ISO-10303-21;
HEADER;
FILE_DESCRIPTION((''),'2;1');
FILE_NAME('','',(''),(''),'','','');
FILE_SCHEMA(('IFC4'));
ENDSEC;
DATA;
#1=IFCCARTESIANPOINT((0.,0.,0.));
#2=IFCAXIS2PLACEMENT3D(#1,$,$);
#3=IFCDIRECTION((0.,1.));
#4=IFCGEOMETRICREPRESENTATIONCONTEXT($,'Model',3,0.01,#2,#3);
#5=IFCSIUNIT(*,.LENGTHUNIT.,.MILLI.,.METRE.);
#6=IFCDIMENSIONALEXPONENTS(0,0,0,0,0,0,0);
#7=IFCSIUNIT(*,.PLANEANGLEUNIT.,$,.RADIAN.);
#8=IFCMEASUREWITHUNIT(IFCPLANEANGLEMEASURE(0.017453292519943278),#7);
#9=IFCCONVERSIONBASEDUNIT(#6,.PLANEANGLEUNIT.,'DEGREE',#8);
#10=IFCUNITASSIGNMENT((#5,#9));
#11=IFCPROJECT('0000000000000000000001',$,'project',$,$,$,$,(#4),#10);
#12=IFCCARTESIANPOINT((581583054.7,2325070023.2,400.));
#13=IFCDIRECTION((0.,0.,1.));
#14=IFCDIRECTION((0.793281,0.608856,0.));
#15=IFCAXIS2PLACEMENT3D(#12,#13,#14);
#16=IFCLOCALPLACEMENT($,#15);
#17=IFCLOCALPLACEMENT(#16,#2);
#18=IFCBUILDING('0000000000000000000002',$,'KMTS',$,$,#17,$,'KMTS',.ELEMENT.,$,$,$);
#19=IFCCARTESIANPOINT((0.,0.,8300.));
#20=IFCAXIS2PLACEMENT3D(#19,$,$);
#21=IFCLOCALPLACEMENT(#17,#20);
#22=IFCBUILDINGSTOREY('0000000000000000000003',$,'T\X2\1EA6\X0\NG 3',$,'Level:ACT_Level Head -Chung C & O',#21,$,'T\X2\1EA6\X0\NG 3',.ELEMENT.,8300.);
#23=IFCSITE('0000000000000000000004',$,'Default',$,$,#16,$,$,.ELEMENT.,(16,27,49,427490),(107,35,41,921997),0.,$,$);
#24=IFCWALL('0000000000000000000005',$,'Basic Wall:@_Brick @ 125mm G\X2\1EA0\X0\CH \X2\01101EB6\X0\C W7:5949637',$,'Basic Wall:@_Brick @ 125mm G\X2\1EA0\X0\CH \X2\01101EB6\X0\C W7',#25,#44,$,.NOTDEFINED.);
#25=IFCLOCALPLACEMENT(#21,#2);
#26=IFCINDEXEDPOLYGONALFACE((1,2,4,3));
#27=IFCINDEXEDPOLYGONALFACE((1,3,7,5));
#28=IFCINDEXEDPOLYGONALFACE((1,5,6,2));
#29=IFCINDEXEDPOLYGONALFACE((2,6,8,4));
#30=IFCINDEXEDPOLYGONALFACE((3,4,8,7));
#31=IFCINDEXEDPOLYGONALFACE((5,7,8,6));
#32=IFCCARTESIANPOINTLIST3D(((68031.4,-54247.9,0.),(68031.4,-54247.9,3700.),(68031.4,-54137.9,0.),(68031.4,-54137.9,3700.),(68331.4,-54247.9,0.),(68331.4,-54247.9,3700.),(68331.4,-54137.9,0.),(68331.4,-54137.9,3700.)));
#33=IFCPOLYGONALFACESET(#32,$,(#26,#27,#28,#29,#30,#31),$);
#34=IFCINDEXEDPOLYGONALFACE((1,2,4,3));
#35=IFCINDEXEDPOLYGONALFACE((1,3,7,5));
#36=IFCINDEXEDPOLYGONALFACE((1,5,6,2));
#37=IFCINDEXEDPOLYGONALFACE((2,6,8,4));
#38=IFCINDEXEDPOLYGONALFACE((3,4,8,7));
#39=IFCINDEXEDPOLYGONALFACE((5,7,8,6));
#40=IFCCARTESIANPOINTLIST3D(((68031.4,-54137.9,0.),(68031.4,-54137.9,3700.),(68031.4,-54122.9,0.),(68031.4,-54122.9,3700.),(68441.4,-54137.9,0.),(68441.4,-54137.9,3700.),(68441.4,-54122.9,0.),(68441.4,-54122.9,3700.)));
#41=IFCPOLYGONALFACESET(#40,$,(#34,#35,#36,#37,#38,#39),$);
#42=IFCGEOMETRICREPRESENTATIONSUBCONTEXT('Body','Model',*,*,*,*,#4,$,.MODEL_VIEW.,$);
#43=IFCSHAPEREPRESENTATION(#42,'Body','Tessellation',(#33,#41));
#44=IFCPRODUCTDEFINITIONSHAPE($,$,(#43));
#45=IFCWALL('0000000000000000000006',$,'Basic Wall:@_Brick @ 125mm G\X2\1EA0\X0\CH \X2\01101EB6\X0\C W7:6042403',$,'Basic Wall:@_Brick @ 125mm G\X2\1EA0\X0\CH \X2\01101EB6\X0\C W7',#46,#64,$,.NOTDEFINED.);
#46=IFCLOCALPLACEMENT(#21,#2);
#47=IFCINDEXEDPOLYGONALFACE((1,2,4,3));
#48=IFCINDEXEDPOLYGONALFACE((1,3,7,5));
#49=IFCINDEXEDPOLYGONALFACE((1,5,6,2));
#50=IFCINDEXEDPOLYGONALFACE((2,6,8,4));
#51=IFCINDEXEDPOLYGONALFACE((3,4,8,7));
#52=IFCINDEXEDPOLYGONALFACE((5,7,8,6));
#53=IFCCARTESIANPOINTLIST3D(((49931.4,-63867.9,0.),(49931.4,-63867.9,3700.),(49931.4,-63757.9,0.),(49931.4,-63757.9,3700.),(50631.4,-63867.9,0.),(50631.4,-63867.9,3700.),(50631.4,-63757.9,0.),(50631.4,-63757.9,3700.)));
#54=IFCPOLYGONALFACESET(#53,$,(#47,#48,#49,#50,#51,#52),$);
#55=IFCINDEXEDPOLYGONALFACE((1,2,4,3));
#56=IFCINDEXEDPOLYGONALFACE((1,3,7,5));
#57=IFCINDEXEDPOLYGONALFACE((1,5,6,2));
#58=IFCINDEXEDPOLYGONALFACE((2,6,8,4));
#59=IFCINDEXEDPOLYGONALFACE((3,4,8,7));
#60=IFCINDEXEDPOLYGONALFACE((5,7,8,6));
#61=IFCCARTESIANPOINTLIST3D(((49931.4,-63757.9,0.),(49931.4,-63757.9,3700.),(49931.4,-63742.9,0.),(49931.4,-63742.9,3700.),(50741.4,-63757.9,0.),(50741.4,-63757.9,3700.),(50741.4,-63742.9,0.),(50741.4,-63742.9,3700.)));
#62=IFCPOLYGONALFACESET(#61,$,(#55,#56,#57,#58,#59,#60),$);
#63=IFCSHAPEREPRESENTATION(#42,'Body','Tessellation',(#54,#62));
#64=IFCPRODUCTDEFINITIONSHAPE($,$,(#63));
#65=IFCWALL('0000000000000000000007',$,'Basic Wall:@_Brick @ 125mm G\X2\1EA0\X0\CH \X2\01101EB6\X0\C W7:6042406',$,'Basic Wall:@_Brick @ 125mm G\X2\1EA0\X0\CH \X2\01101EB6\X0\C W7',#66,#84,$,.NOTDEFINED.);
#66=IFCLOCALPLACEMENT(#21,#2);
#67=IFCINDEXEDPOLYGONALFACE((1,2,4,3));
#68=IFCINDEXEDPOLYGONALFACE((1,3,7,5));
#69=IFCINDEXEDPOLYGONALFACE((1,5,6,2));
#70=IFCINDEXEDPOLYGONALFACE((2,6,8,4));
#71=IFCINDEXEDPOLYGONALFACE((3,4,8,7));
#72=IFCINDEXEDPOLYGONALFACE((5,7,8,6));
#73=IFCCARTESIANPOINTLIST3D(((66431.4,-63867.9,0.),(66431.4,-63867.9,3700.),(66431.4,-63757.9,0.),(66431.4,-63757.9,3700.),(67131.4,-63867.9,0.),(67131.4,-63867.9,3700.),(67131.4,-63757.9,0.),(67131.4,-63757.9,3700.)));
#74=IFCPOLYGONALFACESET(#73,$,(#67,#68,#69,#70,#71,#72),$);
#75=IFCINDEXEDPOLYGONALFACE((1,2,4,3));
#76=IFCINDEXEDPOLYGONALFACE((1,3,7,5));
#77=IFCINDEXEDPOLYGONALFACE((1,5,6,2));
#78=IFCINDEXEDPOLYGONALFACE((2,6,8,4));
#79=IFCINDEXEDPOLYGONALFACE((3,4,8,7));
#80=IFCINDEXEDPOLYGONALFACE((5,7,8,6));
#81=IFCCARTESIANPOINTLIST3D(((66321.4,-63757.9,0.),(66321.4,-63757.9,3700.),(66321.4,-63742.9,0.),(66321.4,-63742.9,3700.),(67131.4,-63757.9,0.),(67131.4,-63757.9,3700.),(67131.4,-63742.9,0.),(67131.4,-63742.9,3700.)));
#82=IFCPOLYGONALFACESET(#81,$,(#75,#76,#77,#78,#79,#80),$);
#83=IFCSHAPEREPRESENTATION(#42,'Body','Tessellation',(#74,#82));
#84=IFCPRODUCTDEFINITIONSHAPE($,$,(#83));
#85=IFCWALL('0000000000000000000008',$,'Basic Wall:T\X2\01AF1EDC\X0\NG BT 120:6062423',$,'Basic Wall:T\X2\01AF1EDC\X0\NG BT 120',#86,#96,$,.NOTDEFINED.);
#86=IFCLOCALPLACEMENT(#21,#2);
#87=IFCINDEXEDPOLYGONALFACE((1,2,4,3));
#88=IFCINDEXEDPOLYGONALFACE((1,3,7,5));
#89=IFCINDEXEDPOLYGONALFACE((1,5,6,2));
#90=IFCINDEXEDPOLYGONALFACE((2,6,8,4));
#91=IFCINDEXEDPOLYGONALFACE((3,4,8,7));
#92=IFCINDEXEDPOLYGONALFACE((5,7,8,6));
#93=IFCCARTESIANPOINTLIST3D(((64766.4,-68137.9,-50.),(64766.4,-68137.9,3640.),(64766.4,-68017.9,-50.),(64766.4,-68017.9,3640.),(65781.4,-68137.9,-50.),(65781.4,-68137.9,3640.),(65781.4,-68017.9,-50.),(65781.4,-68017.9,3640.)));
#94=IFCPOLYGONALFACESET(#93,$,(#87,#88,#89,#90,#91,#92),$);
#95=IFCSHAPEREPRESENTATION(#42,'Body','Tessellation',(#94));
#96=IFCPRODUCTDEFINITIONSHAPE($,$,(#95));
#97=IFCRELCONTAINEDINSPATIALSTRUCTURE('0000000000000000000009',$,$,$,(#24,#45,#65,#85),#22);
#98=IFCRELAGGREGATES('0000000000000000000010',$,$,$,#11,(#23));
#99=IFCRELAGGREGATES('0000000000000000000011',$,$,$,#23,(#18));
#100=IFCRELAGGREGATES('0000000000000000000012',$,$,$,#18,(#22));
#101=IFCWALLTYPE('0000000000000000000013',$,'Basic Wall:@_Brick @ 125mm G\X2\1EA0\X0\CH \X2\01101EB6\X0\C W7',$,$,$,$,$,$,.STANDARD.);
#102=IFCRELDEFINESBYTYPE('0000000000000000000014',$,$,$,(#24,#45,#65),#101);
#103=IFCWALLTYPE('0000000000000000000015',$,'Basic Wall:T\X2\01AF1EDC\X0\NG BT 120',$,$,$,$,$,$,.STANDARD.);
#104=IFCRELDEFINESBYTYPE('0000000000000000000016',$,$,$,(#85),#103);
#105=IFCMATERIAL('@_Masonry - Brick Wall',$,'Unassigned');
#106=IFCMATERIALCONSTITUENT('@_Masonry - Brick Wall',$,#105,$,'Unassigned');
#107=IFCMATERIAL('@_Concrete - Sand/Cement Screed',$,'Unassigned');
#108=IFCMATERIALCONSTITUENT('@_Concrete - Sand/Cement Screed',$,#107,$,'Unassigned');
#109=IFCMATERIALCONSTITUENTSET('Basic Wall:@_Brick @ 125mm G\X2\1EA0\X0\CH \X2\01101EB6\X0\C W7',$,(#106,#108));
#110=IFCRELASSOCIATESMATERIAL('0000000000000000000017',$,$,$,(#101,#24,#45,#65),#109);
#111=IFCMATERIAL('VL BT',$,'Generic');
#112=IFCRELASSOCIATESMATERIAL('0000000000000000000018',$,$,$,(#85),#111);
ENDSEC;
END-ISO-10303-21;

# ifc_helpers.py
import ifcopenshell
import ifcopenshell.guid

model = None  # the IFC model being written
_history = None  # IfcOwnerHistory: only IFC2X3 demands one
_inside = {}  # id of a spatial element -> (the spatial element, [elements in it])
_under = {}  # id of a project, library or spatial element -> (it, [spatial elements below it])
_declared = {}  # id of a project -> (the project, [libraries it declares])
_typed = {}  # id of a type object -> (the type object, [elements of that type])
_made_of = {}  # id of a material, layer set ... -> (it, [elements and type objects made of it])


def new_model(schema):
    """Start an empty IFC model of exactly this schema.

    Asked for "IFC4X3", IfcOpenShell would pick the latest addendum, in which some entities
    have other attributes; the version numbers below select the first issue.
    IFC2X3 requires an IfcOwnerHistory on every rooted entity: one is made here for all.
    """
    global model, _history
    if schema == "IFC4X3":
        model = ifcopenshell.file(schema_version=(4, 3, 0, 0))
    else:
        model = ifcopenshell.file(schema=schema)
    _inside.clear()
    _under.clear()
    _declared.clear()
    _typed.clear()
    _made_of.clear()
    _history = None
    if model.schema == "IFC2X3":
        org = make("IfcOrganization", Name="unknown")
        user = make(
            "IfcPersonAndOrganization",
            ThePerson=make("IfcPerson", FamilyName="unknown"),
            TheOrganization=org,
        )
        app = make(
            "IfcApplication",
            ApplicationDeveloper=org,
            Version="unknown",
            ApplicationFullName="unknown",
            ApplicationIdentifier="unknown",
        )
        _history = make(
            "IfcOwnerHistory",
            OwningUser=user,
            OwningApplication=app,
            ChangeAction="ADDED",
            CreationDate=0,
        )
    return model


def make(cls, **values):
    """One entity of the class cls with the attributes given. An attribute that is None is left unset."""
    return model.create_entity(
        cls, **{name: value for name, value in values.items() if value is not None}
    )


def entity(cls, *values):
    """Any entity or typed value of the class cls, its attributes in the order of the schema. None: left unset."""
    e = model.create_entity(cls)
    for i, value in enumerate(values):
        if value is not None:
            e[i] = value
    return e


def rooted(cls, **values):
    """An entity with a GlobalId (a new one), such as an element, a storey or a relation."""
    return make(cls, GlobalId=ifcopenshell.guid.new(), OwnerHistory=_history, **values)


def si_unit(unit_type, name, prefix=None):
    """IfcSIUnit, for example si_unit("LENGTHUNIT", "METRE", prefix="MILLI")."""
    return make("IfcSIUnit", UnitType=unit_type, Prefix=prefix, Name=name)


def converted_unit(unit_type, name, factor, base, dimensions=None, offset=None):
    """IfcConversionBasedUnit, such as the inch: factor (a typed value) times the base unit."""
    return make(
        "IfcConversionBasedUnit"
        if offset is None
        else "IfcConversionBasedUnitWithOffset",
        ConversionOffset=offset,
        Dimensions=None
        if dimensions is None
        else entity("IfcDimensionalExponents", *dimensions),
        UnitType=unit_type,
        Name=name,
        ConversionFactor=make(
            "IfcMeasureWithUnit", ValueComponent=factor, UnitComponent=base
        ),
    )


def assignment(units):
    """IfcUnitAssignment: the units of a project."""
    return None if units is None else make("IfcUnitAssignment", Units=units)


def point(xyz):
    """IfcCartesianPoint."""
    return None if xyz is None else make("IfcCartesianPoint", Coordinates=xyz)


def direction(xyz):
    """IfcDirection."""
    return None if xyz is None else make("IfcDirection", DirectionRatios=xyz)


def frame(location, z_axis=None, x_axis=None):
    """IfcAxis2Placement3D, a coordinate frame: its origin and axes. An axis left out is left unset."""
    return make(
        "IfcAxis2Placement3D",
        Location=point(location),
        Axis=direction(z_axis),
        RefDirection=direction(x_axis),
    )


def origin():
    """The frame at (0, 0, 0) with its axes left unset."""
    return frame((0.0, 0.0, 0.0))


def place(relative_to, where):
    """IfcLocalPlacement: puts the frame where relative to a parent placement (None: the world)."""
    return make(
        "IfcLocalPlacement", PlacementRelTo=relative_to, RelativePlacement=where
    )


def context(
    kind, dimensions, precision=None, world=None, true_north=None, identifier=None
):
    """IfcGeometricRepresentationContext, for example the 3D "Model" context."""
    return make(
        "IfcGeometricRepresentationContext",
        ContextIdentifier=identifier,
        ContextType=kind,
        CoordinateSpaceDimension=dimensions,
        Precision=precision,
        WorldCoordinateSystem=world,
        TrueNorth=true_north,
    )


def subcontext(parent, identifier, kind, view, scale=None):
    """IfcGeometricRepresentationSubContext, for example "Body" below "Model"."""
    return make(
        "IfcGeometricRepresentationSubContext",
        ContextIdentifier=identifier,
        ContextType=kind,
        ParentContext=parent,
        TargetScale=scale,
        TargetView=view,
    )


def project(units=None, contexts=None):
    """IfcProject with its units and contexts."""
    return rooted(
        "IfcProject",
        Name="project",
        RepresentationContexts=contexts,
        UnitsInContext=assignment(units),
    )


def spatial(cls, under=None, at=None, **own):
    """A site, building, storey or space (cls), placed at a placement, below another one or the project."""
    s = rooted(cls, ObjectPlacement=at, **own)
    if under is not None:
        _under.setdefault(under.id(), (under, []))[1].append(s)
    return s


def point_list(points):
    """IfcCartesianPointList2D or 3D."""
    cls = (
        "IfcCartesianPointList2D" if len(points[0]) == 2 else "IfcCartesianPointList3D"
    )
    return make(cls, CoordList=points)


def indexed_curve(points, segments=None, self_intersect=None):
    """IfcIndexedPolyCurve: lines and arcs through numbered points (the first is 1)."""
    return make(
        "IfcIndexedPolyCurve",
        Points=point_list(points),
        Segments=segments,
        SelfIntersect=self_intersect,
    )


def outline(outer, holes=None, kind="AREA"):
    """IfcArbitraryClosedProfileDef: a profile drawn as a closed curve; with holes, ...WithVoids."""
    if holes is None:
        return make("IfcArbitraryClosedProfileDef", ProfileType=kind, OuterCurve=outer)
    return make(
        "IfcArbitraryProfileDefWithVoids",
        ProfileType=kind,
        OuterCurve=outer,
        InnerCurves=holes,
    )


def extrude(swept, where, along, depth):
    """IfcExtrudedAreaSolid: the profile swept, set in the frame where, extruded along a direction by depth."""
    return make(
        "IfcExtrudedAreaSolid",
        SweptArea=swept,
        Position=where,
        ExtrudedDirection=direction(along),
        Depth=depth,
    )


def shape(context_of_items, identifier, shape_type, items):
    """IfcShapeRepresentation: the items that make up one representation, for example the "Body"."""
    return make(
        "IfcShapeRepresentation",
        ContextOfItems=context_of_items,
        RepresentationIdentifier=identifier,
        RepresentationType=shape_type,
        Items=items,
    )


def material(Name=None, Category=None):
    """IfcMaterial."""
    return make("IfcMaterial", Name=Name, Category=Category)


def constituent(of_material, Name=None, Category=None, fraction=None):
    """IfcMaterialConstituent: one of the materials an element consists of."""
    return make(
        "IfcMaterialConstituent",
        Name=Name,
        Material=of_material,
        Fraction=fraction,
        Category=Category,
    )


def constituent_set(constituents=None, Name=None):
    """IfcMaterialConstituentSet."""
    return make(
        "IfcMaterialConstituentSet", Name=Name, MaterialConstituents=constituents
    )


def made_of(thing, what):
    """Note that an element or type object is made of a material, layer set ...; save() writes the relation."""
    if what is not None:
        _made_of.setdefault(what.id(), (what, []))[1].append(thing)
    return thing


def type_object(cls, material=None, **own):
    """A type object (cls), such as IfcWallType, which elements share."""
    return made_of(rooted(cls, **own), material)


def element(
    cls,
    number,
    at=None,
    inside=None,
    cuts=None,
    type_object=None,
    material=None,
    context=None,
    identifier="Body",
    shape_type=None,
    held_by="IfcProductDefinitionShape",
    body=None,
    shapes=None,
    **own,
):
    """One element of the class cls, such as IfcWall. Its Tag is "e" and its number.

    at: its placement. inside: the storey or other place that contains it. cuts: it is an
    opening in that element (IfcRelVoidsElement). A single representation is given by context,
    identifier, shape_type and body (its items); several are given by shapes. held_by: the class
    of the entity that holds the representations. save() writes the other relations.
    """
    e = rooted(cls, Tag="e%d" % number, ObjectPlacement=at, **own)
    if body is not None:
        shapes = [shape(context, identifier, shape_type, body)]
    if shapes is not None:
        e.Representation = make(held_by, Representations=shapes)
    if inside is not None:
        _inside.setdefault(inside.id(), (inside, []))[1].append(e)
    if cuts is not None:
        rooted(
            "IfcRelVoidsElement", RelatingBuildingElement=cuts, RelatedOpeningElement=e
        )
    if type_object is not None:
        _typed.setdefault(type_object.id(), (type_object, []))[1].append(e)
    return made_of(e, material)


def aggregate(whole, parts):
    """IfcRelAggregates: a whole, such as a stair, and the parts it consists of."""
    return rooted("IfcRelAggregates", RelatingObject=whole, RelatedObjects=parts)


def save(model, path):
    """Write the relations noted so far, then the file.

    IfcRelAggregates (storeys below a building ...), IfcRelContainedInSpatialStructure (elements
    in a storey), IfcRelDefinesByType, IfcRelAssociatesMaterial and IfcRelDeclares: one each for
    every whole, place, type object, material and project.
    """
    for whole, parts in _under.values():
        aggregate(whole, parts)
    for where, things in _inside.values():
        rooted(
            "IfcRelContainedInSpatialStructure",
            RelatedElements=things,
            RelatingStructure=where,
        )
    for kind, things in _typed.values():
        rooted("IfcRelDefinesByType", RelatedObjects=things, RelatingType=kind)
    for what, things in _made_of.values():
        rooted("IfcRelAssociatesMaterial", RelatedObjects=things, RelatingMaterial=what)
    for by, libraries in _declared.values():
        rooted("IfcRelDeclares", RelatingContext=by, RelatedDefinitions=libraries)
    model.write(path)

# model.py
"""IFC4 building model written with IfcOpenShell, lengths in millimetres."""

from ifc_helpers import new_model, entity, si_unit, converted_unit, direction, frame, origin, place, context, subcontext, project, spatial, indexed_curve, outline, extrude, material, constituent, constituent_set, type_object, element, save


model = new_model("IFC4")

# Units and contexts
model_context = context("Model", 3, precision=0.01, world=origin(), true_north=direction((0.0, 1.0)))
body_context = subcontext(model_context, "Body", "Model", "MODEL_VIEW")
ifc_project = project(units=[si_unit("LENGTHUNIT", "METRE", prefix="MILLI"), converted_unit("PLANEANGLEUNIT", "DEGREE", entity("IfcPlaneAngleMeasure", 0.017453292519943278), si_unit("PLANEANGLEUNIT", "RADIAN"), dimensions=[0, 0, 0, 0, 0, 0, 0])], contexts=[model_context])

# Site, building, storey
site_placement = place(None, frame((581583054.7, 2325070023.2, 400.0), z_axis=(0.0, 0.0, 1.0), x_axis=(0.793281, 0.608856, 0.0)))
site = spatial("IfcSite", under=ifc_project, at=site_placement, Name="Default", CompositionType="ELEMENT", RefLatitude=(16, 27, 49, 427490), RefLongitude=(107, 35, 41, 921997), RefElevation=0.0)
building_placement = place(site_placement, origin())
building = spatial("IfcBuilding", under=site, at=building_placement, Name="KMTS", LongName="KMTS", CompositionType="ELEMENT")
storey_placement = place(building_placement, frame((0.0, 0.0, 8300.0)))
storey = spatial("IfcBuildingStorey", under=building, at=storey_placement, Name="TẦNG 3", ObjectType="Level:ACT_Level Head -Chung C & O", LongName="TẦNG 3", CompositionType="ELEMENT", Elevation=8300.0)

# Shared definitions
ifc_material_1 = material(Name="VL BT", Category="Generic")

# Walls
ifc_material_2 = material(Name="@_Masonry - Brick Wall", Category="Unassigned")
ifc_constituent_1 = constituent(ifc_material_2, Name="@_Masonry - Brick Wall", Category="Unassigned")
ifc_material_3 = material(Name="@_Concrete - Sand/Cement Screed", Category="Unassigned")
ifc_constituent_2 = constituent(ifc_material_3, Name="@_Concrete - Sand/Cement Screed", Category="Unassigned")
ifc_constituent_set_1 = constituent_set(constituents=[ifc_constituent_1, ifc_constituent_2], Name="Basic Wall:@_Brick @ 125mm GẠCH ĐẶC W7")
wall_type_1 = type_object("IfcWallType", Name="Basic Wall:@_Brick @ 125mm GẠCH ĐẶC W7", PredefinedType="STANDARD", material=ifc_constituent_set_1)
wall_1_placement = place(storey_placement, frame((68331.4, -54185.4, 0.0), z_axis=(0.0, 0.0, 1.0), x_axis=(-1.0, 0.0, 0.0)))
element("IfcWall", 1, at=wall_1_placement, inside=storey, type_object=wall_type_1, material=ifc_constituent_set_1, Name="Basic Wall:@_Brick @ 125mm GẠCH ĐẶC W7:5949637", ObjectType="Basic Wall:@_Brick @ 125mm GẠCH ĐẶC W7", PredefinedType="NOTDEFINED", context=body_context, shape_type="SweptSolid", body=[
    extrude(outline(indexed_curve([(-55.0, -150.0), (55.0, -150.0), (55.0, 150.0), (-55.0, 150.0), (-55.0, -150.0)], self_intersect=False)), frame((150.0, 7.5, 0.0), z_axis=(0.0, 0.0, 1.0), x_axis=(0.0, -1.0, 0.0)), (0.0, 0.0, 1.0), 3700.0),
    extrude(outline(indexed_curve([(-7.5, -205.0), (7.5, -205.0), (7.5, 205.0), (-7.5, 205.0), (-7.5, -205.0)], self_intersect=False)), frame((95.0, -55.0, 0.0), z_axis=(0.0, 0.0, 1.0), x_axis=(0.0, 1.0, 0.0)), (0.0, 0.0, 1.0), 3700.0),
])
wall_2_placement = place(storey_placement, frame((50631.4, -63805.4, 0.0), z_axis=(0.0, 0.0, 1.0), x_axis=(-1.0, 0.0, 0.0)))
element("IfcWall", 2, at=wall_2_placement, inside=storey, type_object=wall_type_1, material=ifc_constituent_set_1, Name="Basic Wall:@_Brick @ 125mm GẠCH ĐẶC W7:6042403", ObjectType="Basic Wall:@_Brick @ 125mm GẠCH ĐẶC W7", PredefinedType="NOTDEFINED", context=body_context, shape_type="SweptSolid", body=[
    extrude(outline(indexed_curve([(-55.0, -350.0), (55.0, -350.0), (55.0, 350.0), (-55.0, 350.0), (-55.0, -350.0)], self_intersect=False)), frame((350.0, 7.5, 0.0), z_axis=(0.0, 0.0, 1.0), x_axis=(0.0, -1.0, 0.0)), (0.0, 0.0, 1.0), 3700.0),
    extrude(outline(indexed_curve([(-7.5, -405.0), (7.5, -405.0), (7.5, 405.0), (-7.5, 405.0), (-7.5, -405.0)], self_intersect=False)), frame((295.0, -55.0, 0.0), z_axis=(0.0, 0.0, 1.0), x_axis=(0.0, 1.0, 0.0)), (0.0, 0.0, 1.0), 3700.0),
])
wall_3_placement = place(storey_placement, frame((66431.4, -63805.4, 0.0)))
element("IfcWall", 3, at=wall_3_placement, inside=storey, type_object=wall_type_1, material=ifc_constituent_set_1, Name="Basic Wall:@_Brick @ 125mm GẠCH ĐẶC W7:6042406", ObjectType="Basic Wall:@_Brick @ 125mm GẠCH ĐẶC W7", PredefinedType="NOTDEFINED", context=body_context, shape_type="SweptSolid", body=[
    extrude(outline(indexed_curve([(-55.0, -350.0), (55.0, -350.0), (55.0, 350.0), (-55.0, 350.0), (-55.0, -350.0)], self_intersect=False)), frame((350.0, -7.5, 0.0), z_axis=(0.0, 0.0, 1.0), x_axis=(0.0, 1.0, 0.0)), (0.0, 0.0, 1.0), 3700.0),
    extrude(outline(indexed_curve([(-7.5, -405.0), (7.5, -405.0), (7.5, 405.0), (-7.5, 405.0), (-7.5, -405.0)], self_intersect=False)), frame((295.0, 55.0, 0.0), z_axis=(0.0, 0.0, 1.0), x_axis=(0.0, -1.0, 0.0)), (0.0, 0.0, 1.0), 3700.0),
])
wall_type_2 = type_object("IfcWallType", Name="Basic Wall:TƯỜNG BT 120", PredefinedType="STANDARD")
wall_4_placement = place(storey_placement, frame((64766.4, -68077.9, -50.0)))
element("IfcWall", 4, at=wall_4_placement, inside=storey, type_object=wall_type_2, material=ifc_material_1, Name="Basic Wall:TƯỜNG BT 120:6062423", ObjectType="Basic Wall:TƯỜNG BT 120", PredefinedType="NOTDEFINED", context=body_context, shape_type="SweptSolid", body=[
    extrude(outline(indexed_curve([(1015.0, 60.0), (0.0, 60.0), (0.0, -60.0), (1015.0, -60.0), (1015.0, 60.0)], self_intersect=False)), origin(), (0.0, 0.0, 1.0), 3690.0),
])

save(model, "model.ifc")
